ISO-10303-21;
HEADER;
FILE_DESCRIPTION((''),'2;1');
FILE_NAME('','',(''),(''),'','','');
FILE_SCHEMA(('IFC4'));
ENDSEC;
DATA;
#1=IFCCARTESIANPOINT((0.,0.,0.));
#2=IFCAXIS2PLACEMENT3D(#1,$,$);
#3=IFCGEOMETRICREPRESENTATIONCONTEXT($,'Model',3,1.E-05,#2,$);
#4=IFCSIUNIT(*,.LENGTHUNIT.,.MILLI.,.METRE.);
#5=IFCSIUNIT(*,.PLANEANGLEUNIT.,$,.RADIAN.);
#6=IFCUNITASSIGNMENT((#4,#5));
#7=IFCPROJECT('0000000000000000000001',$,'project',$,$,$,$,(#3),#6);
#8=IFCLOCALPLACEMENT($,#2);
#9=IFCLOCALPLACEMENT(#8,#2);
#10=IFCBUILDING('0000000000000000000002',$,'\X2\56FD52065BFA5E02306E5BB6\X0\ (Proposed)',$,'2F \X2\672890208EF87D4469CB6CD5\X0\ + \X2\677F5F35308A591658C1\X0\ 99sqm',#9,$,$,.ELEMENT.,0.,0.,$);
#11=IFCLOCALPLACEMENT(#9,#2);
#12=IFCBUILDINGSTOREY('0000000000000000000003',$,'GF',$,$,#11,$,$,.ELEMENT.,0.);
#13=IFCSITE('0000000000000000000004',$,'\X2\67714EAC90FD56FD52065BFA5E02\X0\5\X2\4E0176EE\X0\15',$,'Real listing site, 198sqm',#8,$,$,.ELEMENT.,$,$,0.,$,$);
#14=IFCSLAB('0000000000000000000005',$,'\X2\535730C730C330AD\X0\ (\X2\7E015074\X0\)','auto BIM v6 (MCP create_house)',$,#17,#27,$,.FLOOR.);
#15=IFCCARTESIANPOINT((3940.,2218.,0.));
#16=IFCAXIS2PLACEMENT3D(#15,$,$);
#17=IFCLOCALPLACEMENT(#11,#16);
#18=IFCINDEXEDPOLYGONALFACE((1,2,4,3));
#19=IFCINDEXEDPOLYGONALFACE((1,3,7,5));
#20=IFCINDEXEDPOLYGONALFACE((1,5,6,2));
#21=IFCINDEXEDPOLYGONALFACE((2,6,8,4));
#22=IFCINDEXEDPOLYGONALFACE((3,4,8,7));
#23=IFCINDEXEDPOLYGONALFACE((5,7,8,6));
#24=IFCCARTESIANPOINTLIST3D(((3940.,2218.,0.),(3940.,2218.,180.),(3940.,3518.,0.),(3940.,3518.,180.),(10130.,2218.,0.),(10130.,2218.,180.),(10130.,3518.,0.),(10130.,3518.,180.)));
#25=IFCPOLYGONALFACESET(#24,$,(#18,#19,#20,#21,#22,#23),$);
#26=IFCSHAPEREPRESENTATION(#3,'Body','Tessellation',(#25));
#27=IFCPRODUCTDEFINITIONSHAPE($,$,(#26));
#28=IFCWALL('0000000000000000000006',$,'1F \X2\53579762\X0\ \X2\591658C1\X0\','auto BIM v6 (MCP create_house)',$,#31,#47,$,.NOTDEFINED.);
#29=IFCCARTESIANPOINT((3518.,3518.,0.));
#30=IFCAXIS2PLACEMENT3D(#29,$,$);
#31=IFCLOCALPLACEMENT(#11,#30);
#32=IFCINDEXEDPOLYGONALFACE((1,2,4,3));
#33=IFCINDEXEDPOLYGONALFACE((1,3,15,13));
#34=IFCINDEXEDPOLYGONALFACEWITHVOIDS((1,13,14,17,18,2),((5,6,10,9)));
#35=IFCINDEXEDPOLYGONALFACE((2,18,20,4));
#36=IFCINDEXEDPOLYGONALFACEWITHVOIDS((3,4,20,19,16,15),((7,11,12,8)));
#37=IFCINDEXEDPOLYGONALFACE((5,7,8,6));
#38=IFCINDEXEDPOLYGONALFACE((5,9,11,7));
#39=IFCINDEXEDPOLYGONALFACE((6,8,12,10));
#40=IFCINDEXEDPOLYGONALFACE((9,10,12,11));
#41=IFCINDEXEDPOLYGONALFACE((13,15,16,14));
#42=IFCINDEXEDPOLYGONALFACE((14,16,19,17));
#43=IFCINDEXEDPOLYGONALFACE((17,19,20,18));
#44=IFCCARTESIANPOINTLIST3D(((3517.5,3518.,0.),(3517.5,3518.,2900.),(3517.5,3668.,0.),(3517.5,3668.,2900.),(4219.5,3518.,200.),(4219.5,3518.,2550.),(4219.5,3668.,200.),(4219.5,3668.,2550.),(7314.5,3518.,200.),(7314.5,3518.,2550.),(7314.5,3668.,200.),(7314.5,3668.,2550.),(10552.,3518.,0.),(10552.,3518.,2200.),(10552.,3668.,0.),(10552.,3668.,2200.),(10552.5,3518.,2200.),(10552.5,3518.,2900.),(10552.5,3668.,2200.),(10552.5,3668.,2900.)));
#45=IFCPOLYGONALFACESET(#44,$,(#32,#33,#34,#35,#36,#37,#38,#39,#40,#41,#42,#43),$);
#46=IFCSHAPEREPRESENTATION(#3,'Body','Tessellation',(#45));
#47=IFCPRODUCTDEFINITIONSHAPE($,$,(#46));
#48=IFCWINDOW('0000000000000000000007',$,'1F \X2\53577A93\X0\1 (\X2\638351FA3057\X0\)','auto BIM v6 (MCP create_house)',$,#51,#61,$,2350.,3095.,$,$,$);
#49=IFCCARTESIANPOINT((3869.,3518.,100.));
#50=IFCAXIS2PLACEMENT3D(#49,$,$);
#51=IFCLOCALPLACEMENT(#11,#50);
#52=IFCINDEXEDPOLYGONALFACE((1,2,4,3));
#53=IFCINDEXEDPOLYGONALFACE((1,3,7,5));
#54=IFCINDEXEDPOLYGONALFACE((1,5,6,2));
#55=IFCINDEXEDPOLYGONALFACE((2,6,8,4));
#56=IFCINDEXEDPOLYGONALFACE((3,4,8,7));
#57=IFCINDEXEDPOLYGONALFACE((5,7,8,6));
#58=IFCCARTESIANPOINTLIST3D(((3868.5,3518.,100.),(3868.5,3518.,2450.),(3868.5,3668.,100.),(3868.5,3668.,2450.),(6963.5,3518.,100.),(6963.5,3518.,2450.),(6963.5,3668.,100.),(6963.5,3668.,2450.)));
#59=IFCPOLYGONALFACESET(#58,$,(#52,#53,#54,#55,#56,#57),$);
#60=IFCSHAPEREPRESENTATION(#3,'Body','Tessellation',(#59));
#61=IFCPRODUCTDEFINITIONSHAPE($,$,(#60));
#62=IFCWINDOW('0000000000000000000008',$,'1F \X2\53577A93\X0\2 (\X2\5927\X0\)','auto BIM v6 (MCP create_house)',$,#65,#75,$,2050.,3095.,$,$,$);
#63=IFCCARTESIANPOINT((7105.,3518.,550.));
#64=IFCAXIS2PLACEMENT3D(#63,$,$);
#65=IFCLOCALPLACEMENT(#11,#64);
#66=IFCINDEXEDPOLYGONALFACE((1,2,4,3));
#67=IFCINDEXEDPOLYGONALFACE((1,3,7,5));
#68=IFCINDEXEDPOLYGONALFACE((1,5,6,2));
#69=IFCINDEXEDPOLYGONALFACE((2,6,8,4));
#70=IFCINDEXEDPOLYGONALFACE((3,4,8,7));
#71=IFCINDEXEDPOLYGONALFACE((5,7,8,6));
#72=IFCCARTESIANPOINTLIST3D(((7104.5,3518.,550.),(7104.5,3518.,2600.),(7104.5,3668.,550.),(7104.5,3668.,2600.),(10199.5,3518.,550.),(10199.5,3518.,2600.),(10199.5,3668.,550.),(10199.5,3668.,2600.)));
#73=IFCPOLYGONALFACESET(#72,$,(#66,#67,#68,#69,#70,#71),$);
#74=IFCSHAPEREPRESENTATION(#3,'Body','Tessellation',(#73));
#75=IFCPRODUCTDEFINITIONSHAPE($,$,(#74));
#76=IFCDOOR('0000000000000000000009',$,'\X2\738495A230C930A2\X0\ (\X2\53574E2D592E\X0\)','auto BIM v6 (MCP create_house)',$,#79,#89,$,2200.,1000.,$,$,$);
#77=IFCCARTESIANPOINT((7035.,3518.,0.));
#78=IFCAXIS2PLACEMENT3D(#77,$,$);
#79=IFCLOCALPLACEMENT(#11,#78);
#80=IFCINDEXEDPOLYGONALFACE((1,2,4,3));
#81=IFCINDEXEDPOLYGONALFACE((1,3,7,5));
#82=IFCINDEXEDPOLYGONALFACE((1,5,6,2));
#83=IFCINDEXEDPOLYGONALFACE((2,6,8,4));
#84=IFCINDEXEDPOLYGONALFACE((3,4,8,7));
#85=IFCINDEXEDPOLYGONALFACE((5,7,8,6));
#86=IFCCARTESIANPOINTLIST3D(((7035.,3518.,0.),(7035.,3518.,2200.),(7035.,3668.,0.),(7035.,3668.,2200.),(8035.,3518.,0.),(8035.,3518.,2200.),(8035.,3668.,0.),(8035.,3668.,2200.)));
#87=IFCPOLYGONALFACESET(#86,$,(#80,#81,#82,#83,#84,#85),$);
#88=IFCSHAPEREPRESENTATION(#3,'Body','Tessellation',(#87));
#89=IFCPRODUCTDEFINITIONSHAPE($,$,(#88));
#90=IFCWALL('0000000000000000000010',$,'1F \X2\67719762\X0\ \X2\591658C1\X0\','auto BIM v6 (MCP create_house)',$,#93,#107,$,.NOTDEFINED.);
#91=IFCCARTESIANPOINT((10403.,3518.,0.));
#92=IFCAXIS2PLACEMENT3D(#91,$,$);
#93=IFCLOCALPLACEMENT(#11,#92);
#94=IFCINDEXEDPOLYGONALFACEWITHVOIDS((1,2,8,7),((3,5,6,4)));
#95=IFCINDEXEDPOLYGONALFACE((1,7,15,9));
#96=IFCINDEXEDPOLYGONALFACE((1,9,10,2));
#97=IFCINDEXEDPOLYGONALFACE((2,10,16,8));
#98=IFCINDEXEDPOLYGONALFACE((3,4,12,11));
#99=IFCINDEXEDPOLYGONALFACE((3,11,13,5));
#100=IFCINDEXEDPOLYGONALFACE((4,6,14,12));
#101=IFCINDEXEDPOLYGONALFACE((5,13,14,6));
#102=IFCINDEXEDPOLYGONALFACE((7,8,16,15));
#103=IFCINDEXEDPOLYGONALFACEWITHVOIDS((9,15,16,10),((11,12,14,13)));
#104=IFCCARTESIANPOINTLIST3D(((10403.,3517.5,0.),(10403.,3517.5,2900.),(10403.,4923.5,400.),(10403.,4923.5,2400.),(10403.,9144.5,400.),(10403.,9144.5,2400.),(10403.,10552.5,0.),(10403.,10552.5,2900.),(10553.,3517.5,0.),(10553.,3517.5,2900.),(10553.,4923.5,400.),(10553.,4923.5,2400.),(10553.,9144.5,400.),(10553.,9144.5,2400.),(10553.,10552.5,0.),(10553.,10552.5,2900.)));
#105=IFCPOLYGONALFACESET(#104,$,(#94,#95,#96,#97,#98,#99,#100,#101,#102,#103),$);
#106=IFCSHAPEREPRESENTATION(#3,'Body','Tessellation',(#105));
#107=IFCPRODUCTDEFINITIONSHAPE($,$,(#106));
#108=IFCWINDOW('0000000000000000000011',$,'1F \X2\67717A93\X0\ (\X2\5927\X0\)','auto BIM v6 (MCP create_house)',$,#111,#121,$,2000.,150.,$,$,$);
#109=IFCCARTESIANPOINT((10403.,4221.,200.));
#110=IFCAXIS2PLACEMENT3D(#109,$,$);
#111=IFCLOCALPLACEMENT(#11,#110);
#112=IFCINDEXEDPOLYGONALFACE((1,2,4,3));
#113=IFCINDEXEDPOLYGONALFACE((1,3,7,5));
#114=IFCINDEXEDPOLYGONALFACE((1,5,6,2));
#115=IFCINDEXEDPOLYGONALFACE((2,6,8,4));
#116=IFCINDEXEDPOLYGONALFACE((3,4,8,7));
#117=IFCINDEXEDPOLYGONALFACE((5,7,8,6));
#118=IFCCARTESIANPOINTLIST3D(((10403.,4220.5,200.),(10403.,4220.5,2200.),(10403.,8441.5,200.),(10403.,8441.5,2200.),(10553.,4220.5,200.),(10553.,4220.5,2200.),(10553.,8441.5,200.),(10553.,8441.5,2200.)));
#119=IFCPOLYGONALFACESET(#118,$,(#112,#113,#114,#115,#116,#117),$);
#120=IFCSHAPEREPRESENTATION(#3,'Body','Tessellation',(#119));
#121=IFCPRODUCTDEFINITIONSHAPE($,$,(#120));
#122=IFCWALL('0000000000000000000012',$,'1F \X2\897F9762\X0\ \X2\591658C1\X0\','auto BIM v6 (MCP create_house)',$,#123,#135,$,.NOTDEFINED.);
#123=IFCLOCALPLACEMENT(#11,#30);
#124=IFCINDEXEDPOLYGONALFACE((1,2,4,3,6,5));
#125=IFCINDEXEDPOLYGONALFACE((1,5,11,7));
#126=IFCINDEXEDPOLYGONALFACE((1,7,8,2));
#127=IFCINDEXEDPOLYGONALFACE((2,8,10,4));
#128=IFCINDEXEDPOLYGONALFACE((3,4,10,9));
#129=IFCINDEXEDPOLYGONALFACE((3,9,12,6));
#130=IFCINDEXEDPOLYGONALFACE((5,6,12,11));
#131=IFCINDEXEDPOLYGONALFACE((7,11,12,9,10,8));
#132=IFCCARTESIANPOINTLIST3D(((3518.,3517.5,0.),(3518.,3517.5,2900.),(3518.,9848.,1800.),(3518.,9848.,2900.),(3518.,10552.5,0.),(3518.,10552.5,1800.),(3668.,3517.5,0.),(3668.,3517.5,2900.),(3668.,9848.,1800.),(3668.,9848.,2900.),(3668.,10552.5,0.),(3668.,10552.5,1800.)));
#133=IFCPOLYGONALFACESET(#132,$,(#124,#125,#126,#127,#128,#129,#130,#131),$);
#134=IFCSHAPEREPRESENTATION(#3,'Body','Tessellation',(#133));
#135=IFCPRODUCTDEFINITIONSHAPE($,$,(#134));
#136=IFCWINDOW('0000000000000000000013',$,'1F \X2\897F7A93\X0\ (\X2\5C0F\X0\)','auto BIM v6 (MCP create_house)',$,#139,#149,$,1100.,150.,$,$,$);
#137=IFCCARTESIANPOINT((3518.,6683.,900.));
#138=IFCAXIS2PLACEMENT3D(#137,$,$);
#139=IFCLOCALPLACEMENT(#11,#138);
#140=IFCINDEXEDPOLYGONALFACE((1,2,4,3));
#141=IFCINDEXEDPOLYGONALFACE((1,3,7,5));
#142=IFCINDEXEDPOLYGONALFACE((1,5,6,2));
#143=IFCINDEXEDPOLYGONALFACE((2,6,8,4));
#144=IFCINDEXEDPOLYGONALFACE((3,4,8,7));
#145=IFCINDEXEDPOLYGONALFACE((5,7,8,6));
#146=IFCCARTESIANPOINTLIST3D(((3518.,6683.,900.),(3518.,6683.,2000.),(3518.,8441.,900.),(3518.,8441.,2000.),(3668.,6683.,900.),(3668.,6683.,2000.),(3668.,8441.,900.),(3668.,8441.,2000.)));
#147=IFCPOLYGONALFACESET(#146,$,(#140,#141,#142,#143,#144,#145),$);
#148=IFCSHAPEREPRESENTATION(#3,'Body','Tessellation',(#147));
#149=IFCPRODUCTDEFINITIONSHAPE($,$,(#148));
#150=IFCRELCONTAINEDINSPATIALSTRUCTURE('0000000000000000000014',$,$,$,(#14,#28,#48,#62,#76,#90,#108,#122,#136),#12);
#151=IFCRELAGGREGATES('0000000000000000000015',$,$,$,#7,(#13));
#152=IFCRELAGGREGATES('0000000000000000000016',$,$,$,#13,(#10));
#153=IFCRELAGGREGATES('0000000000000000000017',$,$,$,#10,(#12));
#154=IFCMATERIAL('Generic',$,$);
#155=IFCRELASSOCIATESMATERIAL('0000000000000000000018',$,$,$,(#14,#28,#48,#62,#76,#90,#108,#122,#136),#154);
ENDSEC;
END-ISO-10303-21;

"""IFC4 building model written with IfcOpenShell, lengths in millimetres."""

from ifc_helpers import new_model, si_unit, frame, frame_2d, origin, place, context, project, spatial, rectangle, extrude, material, element, fill, save


model = new_model("IFC4")

# Units and contexts
model_context = context("Model", 3, precision=1e-05, world=origin())
ifc_project = project(units=[si_unit("LENGTHUNIT", "METRE", prefix="MILLI"), si_unit("PLANEANGLEUNIT", "RADIAN")], contexts=[model_context])

# Site, building, storey
site_placement = place(None, origin())
site = spatial("IfcSite", under=ifc_project, at=site_placement, Name="東京都国分寺市5丁目15", ObjectType="Real listing site, 198sqm", CompositionType="ELEMENT", RefElevation=0.0)
building_placement = place(site_placement, origin())
building = spatial("IfcBuilding", under=site, at=building_placement, Name="国分寺市の家 (Proposed)", ObjectType="2F 木造軸組構法 + 板張り外壁 99sqm", CompositionType="ELEMENT", ElevationOfRefHeight=0.0, ElevationOfTerrain=0.0)
storey_placement = place(building_placement, origin())
storey = spatial("IfcBuildingStorey", under=building, at=storey_placement, Name="GF", CompositionType="ELEMENT", Elevation=0.0)

# Slab
ifc_material = material(Name="Generic")
slab_1_placement = place(storey_placement, frame((3940.0, 2218.0, 0.0)))
element("IfcSlab", 1, at=slab_1_placement, inside=storey, material=ifc_material, Name="南デッキ (縁側)", Description="auto BIM v6 (MCP create_house)", PredefinedType="FLOOR", context=model_context, shape_type="SweptSolid", body=[
    extrude(rectangle(XDim=6190.0, YDim=1300.0, at=frame_2d((3095.0, 650.0))), frame((3940.0, 2218.0, 0.0)), (0.0, 0.0, 1.0), 180.0),
])

# Wall, openings, windows, door
wall_1_placement = place(storey_placement, frame((3518.0, 3518.0, 0.0)))
wall_1 = element("IfcWall", 2, at=wall_1_placement, inside=storey, material=ifc_material, Name="1F 南面 外壁", Description="auto BIM v6 (MCP create_house)", PredefinedType="NOTDEFINED", context=model_context, shape_type="SweptSolid", body=[
    extrude(rectangle(XDim=7035.0, YDim=150.0, at=frame_2d((3517.0, 75.0))), frame((3518.0, 3518.0, 0.0)), (0.0, 0.0, 1.0), 2900.0),
])
opening_1_placement = place(storey_placement, frame((3869.0, 3518.0, 100.0)))
opening_1 = element("IfcOpeningElement", 3, at=opening_1_placement, cuts=wall_1, PredefinedType="NOTDEFINED", context=model_context, shape_type="SweptSolid", body=[
    extrude(rectangle(XDim=3095.0, YDim=150.0, at=frame_2d((1547.0, 75.0))), frame((3869.0, 3518.0, 100.0)), (0.0, 0.0, 1.0), 2350.0),
])
opening_2_placement = place(storey_placement, frame((7105.0, 3518.0, 550.0)))
opening_2 = element("IfcOpeningElement", 4, at=opening_2_placement, cuts=wall_1, PredefinedType="NOTDEFINED", context=model_context, shape_type="SweptSolid", body=[
    extrude(rectangle(XDim=3095.0, YDim=150.0, at=frame_2d((1547.0, 75.0))), frame((7105.0, 3518.0, 550.0)), (0.0, 0.0, 1.0), 2050.0),
])
opening_3_placement = place(storey_placement, frame((7035.0, 3518.0, 0.0)))
opening_3 = element("IfcOpeningElement", 5, at=opening_3_placement, cuts=wall_1, PredefinedType="NOTDEFINED", context=model_context, shape_type="SweptSolid", body=[
    extrude(rectangle(XDim=1000.0, YDim=150.0, at=frame_2d((500.0, 75.0))), frame((7035.0, 3518.0, 0.0)), (0.0, 0.0, 1.0), 2200.0),
])
window_1_placement = place(storey_placement, frame((3869.0, 3518.0, 100.0)))
window_1 = element("IfcWindow", 6, at=window_1_placement, inside=storey, material=ifc_material, Name="1F 南窓1 (掃出し)", Description="auto BIM v6 (MCP create_house)", OverallHeight=2350.0, OverallWidth=3095.0, context=model_context, shape_type="SweptSolid", body=[
    extrude(rectangle(XDim=3095.0, YDim=150.0, at=frame_2d((1547.0, 75.0))), frame((3869.0, 3518.0, 100.0)), (0.0, 0.0, 1.0), 2350.0),
])
fill(opening_1, window_1)
window_2_placement = place(storey_placement, frame((7105.0, 3518.0, 550.0)))
window_2 = element("IfcWindow", 7, at=window_2_placement, inside=storey, material=ifc_material, Name="1F 南窓2 (大)", Description="auto BIM v6 (MCP create_house)", OverallHeight=2050.0, OverallWidth=3095.0, context=model_context, shape_type="SweptSolid", body=[
    extrude(rectangle(XDim=3095.0, YDim=150.0, at=frame_2d((1547.0, 75.0))), frame((7105.0, 3518.0, 550.0)), (0.0, 0.0, 1.0), 2050.0),
])
fill(opening_2, window_2)
door_placement = place(storey_placement, frame((7035.0, 3518.0, 0.0)))
door = element("IfcDoor", 8, at=door_placement, inside=storey, material=ifc_material, Name="玄関ドア (南中央)", Description="auto BIM v6 (MCP create_house)", OverallHeight=2200.0, OverallWidth=1000.0, context=model_context, shape_type="SweptSolid", body=[
    extrude(rectangle(XDim=1000.0, YDim=150.0, at=frame_2d((500.0, 75.0))), frame((7035.0, 3518.0, 0.0)), (0.0, 0.0, 1.0), 2200.0),
])
fill(opening_3, door)

# Walls, openings, windows
wall_2_placement = place(storey_placement, frame((10403.0, 3518.0, 0.0)))
wall_2 = element("IfcWall", 9, at=wall_2_placement, inside=storey, material=ifc_material, Name="1F 東面 外壁", Description="auto BIM v6 (MCP create_house)", PredefinedType="NOTDEFINED", context=model_context, shape_type="SweptSolid", body=[
    extrude(rectangle(XDim=150.0, YDim=7035.0, at=frame_2d((75.0, 3517.0))), frame((10403.0, 3518.0, 0.0)), (0.0, 0.0, 1.0), 2900.0),
])
opening_4_placement = place(storey_placement, frame((10403.0, 4221.0, 200.0)))
opening_4 = element("IfcOpeningElement", 10, at=opening_4_placement, cuts=wall_2, PredefinedType="NOTDEFINED", context=model_context, shape_type="SweptSolid", body=[
    extrude(rectangle(XDim=150.0, YDim=4221.0, at=frame_2d((75.0, 2110.0))), frame((10403.0, 4221.0, 200.0)), (0.0, 0.0, 1.0), 2000.0),
])
window_3_placement = place(storey_placement, frame((10403.0, 4221.0, 200.0)))
window_3 = element("IfcWindow", 11, at=window_3_placement, inside=storey, material=ifc_material, Name="1F 東窓 (大)", Description="auto BIM v6 (MCP create_house)", OverallHeight=2000.0, OverallWidth=150.0, context=model_context, shape_type="SweptSolid", body=[
    extrude(rectangle(XDim=150.0, YDim=4221.0, at=frame_2d((75.0, 2110.0))), frame((10403.0, 4221.0, 200.0)), (0.0, 0.0, 1.0), 2000.0),
])
fill(opening_4, window_3)
wall_3_placement = place(storey_placement, frame((3518.0, 3518.0, 0.0)))
wall_3 = element("IfcWall", 12, at=wall_3_placement, inside=storey, material=ifc_material, Name="1F 西面 外壁", Description="auto BIM v6 (MCP create_house)", PredefinedType="NOTDEFINED", context=model_context, shape_type="SweptSolid", body=[
    extrude(rectangle(XDim=150.0, YDim=7035.0, at=frame_2d((75.0, 3517.0))), frame((3518.0, 3518.0, 0.0)), (0.0, 0.0, 1.0), 2900.0),
])
opening_5_placement = place(storey_placement, frame((3518.0, 6683.0, 900.0)))
opening_5 = element("IfcOpeningElement", 13, at=opening_5_placement, cuts=wall_3, PredefinedType="NOTDEFINED", context=model_context, shape_type="SweptSolid", body=[
    extrude(rectangle(XDim=150.0, YDim=1758.0, at=frame_2d((75.0, 879.0))), frame((3518.0, 6683.0, 900.0)), (0.0, 0.0, 1.0), 1100.0),
])
window_4_placement = place(storey_placement, frame((3518.0, 6683.0, 900.0)))
window_4 = element("IfcWindow", 14, at=window_4_placement, inside=storey, material=ifc_material, Name="1F 西窓 (小)", Description="auto BIM v6 (MCP create_house)", OverallHeight=1100.0, OverallWidth=150.0, context=model_context, shape_type="SweptSolid", body=[
    extrude(rectangle(XDim=150.0, YDim=1758.0, at=frame_2d((75.0, 879.0))), frame((3518.0, 6683.0, 900.0)), (0.0, 0.0, 1.0), 1100.0),
])
fill(opening_5, window_4)

save(model, "model.ifc")
